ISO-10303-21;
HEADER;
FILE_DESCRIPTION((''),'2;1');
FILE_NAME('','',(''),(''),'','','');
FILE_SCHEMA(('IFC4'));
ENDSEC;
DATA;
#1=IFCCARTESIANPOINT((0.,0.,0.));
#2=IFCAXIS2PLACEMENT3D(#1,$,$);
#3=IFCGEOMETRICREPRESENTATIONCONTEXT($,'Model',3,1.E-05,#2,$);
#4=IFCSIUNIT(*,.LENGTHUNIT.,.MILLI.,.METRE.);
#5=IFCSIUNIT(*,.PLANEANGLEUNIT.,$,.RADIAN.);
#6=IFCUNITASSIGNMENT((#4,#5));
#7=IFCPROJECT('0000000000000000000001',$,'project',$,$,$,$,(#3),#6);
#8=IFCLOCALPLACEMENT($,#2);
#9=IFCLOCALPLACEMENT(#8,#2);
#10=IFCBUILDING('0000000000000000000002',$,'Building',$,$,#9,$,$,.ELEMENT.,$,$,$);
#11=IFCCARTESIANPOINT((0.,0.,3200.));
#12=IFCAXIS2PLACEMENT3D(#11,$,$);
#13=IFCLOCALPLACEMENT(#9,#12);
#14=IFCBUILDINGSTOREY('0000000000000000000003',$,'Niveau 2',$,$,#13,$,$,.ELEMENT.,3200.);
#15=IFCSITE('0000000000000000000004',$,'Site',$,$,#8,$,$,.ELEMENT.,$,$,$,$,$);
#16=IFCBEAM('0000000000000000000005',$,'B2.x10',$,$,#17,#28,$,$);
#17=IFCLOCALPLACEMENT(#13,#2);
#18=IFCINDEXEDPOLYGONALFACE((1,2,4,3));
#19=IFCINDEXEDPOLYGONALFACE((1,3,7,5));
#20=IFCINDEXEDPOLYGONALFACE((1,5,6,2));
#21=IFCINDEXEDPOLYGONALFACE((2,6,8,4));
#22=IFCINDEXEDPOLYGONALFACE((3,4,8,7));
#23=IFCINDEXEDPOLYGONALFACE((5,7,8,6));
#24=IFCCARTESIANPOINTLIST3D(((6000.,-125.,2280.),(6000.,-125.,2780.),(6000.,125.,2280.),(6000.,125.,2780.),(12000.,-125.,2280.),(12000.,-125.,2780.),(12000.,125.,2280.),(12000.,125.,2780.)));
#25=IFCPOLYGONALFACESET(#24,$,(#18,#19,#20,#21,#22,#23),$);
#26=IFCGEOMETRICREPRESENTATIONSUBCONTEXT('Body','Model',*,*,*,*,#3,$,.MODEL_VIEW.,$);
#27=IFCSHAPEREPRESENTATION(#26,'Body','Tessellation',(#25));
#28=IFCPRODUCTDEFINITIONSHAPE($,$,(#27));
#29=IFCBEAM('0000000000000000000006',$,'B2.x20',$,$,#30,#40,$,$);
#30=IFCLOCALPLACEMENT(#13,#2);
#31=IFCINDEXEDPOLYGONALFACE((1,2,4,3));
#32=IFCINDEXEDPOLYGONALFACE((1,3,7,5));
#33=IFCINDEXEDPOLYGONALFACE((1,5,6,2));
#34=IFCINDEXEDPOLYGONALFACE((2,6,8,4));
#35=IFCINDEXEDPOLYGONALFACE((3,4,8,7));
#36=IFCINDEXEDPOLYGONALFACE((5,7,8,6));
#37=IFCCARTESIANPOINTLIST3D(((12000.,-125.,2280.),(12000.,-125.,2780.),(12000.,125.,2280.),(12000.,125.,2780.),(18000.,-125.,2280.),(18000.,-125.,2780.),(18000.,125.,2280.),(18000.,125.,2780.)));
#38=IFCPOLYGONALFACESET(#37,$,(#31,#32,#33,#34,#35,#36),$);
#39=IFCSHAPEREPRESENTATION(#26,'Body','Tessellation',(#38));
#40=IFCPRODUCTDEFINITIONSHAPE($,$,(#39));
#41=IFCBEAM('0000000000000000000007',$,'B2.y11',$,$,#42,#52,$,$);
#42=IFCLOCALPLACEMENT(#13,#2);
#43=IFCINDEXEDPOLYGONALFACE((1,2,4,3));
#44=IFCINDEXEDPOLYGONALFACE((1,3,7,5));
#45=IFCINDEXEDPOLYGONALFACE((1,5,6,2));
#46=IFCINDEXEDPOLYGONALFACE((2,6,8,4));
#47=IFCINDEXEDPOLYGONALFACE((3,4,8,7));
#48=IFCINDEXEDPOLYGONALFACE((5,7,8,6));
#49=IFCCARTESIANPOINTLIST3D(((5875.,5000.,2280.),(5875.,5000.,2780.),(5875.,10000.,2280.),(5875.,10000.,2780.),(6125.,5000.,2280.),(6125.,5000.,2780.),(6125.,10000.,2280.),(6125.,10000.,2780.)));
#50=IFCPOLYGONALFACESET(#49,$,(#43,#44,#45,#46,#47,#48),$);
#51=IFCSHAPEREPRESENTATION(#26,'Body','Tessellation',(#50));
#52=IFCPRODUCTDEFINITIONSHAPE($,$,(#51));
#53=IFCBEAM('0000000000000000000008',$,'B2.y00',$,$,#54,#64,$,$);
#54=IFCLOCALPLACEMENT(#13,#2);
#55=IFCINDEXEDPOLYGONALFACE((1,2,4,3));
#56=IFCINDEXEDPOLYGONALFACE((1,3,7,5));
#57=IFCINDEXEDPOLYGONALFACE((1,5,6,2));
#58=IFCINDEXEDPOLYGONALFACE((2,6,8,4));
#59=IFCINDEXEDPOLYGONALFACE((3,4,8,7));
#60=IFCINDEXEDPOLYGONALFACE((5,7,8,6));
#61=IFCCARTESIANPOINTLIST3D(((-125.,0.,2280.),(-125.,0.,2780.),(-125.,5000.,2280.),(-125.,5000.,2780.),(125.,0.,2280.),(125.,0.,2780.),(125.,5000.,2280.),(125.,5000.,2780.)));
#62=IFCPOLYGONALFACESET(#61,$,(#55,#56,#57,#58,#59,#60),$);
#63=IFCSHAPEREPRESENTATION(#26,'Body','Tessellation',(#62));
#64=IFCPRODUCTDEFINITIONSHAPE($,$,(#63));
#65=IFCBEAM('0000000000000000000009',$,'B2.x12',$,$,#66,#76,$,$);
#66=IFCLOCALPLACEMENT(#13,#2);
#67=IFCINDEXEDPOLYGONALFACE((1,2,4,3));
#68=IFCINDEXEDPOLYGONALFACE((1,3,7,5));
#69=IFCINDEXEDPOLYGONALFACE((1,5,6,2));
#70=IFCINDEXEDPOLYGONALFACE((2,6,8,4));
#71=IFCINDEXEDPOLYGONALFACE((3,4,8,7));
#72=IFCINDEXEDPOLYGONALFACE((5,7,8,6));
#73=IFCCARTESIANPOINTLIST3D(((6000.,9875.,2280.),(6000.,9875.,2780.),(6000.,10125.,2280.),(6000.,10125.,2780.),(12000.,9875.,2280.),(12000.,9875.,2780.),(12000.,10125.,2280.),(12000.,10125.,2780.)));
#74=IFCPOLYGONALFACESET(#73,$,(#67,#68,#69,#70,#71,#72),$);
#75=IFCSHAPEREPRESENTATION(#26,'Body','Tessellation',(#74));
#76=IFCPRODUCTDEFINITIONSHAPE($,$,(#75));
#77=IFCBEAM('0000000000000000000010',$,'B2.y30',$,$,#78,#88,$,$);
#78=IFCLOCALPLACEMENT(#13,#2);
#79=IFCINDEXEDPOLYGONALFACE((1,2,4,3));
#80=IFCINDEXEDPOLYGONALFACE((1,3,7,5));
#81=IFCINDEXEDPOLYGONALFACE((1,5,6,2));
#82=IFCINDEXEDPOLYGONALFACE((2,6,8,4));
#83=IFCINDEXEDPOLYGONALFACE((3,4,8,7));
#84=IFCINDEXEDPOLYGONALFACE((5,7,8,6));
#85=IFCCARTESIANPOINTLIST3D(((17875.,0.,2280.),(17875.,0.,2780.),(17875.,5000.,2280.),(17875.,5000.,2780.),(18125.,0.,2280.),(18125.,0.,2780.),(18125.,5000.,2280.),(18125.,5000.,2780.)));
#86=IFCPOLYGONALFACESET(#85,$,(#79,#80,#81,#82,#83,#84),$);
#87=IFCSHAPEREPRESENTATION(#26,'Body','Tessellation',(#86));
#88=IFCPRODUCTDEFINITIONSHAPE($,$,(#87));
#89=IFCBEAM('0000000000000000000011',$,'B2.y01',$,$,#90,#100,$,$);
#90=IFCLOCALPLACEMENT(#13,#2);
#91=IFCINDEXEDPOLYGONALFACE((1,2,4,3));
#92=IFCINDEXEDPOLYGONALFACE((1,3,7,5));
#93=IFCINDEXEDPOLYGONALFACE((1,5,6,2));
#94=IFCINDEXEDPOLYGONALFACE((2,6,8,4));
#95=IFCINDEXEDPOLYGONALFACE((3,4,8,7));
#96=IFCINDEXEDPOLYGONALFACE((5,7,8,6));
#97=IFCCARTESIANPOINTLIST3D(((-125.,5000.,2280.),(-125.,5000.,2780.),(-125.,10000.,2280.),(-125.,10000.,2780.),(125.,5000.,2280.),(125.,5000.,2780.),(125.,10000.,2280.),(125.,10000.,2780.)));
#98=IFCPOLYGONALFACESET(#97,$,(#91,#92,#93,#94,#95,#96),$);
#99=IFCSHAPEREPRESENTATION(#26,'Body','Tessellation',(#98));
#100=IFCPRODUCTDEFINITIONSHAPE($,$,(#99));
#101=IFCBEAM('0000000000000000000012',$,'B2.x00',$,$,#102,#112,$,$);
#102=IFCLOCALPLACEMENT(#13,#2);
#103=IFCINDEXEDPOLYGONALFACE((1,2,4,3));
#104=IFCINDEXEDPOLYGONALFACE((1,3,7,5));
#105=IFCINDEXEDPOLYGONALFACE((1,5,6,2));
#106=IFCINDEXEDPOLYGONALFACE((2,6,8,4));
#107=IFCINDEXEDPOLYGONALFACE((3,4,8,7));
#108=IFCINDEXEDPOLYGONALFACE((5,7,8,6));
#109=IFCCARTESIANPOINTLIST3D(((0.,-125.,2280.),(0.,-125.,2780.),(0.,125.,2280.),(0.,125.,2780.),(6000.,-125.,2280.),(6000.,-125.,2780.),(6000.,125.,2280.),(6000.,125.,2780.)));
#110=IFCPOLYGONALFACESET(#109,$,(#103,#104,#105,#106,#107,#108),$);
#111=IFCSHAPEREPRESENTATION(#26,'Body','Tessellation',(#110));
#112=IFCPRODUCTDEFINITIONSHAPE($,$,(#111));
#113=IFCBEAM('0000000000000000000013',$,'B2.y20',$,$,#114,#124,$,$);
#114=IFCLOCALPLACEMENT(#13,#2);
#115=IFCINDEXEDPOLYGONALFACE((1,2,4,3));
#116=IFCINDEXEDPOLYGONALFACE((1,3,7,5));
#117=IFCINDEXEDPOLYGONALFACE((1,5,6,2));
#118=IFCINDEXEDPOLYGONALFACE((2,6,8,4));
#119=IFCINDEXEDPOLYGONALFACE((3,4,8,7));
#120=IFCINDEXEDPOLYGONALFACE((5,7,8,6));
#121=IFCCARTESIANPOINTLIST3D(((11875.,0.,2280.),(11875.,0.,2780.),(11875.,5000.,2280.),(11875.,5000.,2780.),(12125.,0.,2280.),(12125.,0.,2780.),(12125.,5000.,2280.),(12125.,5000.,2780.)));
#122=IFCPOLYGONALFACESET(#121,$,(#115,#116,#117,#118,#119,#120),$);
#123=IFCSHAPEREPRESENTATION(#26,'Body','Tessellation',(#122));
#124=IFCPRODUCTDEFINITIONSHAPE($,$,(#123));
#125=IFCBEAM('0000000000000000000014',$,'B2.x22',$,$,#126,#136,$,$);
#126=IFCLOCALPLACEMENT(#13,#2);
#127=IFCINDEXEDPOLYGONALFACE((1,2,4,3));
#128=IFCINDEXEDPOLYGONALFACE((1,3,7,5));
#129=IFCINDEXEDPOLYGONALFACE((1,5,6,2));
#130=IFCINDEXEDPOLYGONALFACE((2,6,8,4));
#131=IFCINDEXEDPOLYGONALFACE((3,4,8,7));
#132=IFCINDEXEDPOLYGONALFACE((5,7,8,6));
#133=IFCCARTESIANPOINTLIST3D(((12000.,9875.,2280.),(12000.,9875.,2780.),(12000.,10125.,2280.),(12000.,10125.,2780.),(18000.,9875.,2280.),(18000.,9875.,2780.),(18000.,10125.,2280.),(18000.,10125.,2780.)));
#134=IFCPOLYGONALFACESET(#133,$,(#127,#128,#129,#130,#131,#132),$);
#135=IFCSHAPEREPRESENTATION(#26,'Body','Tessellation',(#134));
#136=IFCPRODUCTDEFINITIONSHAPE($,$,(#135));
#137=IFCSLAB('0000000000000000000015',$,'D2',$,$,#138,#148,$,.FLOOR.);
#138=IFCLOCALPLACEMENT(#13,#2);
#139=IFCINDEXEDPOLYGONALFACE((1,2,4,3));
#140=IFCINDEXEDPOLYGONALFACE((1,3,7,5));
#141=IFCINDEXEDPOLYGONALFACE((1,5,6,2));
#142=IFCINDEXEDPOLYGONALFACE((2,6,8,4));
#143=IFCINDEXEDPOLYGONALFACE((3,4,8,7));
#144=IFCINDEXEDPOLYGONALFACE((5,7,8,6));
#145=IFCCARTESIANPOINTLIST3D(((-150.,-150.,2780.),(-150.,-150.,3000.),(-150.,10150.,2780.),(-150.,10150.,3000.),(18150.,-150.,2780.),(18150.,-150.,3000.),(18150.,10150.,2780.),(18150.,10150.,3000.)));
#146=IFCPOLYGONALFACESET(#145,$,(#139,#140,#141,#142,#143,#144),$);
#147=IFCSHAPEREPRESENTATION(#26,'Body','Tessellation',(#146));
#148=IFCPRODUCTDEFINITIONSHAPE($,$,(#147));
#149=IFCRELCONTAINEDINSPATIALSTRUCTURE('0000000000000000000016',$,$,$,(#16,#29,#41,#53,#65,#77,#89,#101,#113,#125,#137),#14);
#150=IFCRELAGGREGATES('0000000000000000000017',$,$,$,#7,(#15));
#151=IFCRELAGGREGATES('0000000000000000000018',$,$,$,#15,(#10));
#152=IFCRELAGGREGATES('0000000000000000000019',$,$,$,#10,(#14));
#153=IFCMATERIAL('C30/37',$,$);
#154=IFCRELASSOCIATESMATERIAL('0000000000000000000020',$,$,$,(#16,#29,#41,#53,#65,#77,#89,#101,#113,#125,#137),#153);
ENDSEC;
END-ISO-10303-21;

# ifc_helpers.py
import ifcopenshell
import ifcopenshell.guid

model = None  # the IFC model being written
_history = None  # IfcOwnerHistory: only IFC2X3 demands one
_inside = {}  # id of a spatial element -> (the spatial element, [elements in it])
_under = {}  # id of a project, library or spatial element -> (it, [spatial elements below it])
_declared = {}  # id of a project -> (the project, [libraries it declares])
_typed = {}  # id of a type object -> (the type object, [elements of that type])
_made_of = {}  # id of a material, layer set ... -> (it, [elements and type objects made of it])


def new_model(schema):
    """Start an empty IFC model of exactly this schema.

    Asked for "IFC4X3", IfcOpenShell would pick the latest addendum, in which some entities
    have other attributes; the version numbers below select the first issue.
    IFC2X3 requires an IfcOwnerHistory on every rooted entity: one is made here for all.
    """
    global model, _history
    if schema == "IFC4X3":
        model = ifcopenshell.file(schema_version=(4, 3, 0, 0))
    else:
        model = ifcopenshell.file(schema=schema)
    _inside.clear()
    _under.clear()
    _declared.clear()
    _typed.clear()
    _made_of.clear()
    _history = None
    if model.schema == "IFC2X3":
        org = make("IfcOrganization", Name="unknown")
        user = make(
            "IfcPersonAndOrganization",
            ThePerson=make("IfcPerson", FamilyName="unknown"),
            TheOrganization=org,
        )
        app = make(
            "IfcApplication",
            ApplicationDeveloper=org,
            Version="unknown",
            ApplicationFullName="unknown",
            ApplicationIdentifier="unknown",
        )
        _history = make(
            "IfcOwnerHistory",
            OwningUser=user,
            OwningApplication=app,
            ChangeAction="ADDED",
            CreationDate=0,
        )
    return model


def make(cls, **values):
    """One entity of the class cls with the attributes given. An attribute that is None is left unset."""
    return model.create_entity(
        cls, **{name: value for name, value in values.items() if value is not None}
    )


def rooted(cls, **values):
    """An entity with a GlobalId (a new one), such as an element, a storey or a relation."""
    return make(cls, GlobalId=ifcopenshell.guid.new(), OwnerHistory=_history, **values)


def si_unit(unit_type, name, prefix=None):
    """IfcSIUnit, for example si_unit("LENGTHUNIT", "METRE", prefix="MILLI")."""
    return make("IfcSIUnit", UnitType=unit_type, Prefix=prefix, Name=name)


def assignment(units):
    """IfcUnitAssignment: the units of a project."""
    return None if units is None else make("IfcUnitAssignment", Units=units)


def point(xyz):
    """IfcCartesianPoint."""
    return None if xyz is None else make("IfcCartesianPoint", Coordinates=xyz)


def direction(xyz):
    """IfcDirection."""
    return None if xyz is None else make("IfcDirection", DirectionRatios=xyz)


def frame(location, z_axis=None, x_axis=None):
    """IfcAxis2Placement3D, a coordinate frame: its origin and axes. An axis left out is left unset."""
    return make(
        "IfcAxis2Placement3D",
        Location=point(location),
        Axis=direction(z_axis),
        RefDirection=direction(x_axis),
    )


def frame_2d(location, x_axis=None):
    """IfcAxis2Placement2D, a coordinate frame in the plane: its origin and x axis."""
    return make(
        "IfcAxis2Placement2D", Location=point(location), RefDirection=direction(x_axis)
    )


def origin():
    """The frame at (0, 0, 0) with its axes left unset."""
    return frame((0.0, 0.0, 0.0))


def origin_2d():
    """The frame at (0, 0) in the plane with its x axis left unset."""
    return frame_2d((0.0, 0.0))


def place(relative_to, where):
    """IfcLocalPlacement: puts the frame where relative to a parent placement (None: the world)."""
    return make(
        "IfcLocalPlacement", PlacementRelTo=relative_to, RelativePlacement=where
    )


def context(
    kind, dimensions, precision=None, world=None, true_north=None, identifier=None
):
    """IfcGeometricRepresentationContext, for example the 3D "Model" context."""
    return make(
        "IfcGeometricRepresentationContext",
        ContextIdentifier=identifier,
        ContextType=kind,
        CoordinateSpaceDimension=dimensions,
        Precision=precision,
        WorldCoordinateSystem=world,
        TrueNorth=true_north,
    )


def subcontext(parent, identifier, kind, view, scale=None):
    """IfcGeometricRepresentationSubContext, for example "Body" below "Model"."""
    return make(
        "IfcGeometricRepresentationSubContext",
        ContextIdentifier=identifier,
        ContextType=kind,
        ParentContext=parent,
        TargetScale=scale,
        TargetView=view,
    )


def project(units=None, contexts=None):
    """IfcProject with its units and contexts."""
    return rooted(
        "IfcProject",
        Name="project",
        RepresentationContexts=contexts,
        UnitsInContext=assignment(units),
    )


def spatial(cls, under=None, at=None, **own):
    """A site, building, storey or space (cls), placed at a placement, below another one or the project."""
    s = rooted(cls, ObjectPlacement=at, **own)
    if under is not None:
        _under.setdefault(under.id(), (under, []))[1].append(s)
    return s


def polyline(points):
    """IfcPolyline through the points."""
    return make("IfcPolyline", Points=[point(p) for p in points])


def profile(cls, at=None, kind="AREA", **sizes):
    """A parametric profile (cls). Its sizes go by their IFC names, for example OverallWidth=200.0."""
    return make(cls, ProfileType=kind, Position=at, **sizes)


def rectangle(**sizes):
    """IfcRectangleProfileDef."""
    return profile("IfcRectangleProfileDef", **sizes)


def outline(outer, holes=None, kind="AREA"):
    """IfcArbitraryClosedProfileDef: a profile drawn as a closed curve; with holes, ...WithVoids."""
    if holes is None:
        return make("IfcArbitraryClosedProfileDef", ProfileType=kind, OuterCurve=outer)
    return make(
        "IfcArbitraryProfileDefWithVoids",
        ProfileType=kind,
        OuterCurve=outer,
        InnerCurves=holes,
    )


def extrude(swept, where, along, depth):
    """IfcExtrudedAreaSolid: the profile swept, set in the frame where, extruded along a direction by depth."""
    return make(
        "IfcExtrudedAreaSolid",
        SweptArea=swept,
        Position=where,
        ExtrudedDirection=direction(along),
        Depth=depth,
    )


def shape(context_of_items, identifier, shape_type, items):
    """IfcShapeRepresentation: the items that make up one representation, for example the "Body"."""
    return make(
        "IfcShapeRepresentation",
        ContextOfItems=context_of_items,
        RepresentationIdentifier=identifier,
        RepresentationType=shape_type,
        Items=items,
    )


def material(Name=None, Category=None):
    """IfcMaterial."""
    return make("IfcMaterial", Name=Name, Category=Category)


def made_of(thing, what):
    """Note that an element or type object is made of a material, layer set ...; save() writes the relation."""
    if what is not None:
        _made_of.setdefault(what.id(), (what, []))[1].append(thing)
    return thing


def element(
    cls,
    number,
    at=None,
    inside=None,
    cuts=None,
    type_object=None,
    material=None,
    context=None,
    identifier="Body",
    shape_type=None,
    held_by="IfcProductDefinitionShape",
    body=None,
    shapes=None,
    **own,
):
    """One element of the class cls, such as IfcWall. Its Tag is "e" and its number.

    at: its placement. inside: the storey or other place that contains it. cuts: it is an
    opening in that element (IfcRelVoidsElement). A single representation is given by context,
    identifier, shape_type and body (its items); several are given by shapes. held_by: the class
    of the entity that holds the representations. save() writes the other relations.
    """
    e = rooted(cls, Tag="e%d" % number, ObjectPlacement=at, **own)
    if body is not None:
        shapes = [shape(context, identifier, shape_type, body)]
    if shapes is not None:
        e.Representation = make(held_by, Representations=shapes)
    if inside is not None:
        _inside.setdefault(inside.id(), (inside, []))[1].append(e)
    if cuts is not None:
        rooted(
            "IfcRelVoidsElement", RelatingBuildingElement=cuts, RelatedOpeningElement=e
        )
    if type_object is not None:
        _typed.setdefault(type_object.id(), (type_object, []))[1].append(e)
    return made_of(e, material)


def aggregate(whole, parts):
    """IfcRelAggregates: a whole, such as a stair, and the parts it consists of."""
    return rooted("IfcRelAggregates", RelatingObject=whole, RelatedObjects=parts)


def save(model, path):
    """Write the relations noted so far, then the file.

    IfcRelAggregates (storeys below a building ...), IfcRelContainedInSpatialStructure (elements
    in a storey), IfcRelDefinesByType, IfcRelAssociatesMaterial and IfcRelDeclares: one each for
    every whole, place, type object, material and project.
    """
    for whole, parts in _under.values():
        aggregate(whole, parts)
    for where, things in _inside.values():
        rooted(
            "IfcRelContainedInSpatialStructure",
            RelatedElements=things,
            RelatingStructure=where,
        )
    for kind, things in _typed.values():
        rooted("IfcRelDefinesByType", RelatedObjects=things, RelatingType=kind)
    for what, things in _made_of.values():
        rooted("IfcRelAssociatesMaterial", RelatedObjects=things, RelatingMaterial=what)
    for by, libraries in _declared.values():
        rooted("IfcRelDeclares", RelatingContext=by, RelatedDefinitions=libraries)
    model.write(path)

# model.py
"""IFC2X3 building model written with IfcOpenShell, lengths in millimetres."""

from ifc_helpers import new_model, si_unit, frame, origin, origin_2d, place, context, subcontext, project, spatial, polyline, rectangle, outline, extrude, material, element, save


model = new_model("IFC2X3")

# Units and contexts
model_context = context("Model", 3, precision=1e-05, world=origin())
body_context = subcontext(model_context, "Body", "Model", "MODEL_VIEW")
ifc_project = project(units=[si_unit("LENGTHUNIT", "METRE", prefix="MILLI"), si_unit("PLANEANGLEUNIT", "RADIAN")], contexts=[model_context])

# Site, building, storey
site_placement = place(None, origin())
site = spatial("IfcSite", under=ifc_project, at=site_placement, Name="Site", CompositionType="ELEMENT")
building_placement = place(site_placement, origin())
building = spatial("IfcBuilding", under=site, at=building_placement, Name="Building", CompositionType="ELEMENT")
storey_placement = place(building_placement, frame((0.0, 0.0, 3200.0)))
storey = spatial("IfcBuildingStorey", under=building, at=storey_placement, Name="Niveau 2", CompositionType="ELEMENT", Elevation=3200.0)

# Shared definitions
ifc_material = material(Name="C30/37")

# Beams
for number, where, z_axis, x_axis, name in (
    (1, (6000.0, 0.0, 2530.0), (1.0, 0.0, 0.0), (0.0, 1.0, 0.0), "B2.x10"),
    (2, (12000.0, 0.0, 2530.0), (1.0, 0.0, 0.0), (0.0, 1.0, 0.0), "B2.x20"),
):
    element("IfcBeam", number, at=place(storey_placement, frame(where, z_axis=z_axis, x_axis=x_axis)), inside=storey, material=ifc_material, Name=name, context=body_context, shape_type="SweptSolid", body=[
        extrude(rectangle(XDim=250.0, YDim=500.0, at=origin_2d()), origin(), (0.0, 0.0, 1.0), 6000.0),
    ])
for number, where, z_axis, x_axis, name in (
    (3, (6000.0, 5000.0, 2530.0), (0.0, 1.0, 0.0), (-1.0, 0.0, 0.0), "B2.y11"),
    (4, (0.0, 0.0, 2530.0), (0.0, 1.0, 0.0), (-1.0, 0.0, 0.0), "B2.y00"),
):
    element("IfcBeam", number, at=place(storey_placement, frame(where, z_axis=z_axis, x_axis=x_axis)), inside=storey, material=ifc_material, Name=name, context=body_context, shape_type="SweptSolid", body=[
        extrude(rectangle(XDim=250.0, YDim=500.0, at=origin_2d()), origin(), (0.0, 0.0, 1.0), 5000.0),
    ])
beam_1_placement = place(storey_placement, frame((6000.0, 10000.0, 2530.0), z_axis=(1.0, 0.0, 0.0), x_axis=(0.0, 1.0, 0.0)))
element("IfcBeam", 5, at=beam_1_placement, inside=storey, material=ifc_material, Name="B2.x12", context=body_context, shape_type="SweptSolid", body=[
    extrude(rectangle(XDim=250.0, YDim=500.0, at=origin_2d()), origin(), (0.0, 0.0, 1.0), 6000.0),
])
for number, where, z_axis, x_axis, name in (
    (6, (18000.0, 0.0, 2530.0), (0.0, 1.0, 0.0), (-1.0, 0.0, 0.0), "B2.y30"),
    (7, (0.0, 5000.0, 2530.0), (0.0, 1.0, 0.0), (-1.0, 0.0, 0.0), "B2.y01"),
):
    element("IfcBeam", number, at=place(storey_placement, frame(where, z_axis=z_axis, x_axis=x_axis)), inside=storey, material=ifc_material, Name=name, context=body_context, shape_type="SweptSolid", body=[
        extrude(rectangle(XDim=250.0, YDim=500.0, at=origin_2d()), origin(), (0.0, 0.0, 1.0), 5000.0),
    ])
beam_2_placement = place(storey_placement, frame((0.0, 0.0, 2530.0), z_axis=(1.0, 0.0, 0.0), x_axis=(0.0, 1.0, 0.0)))
element("IfcBeam", 8, at=beam_2_placement, inside=storey, material=ifc_material, Name="B2.x00", context=body_context, shape_type="SweptSolid", body=[
    extrude(rectangle(XDim=250.0, YDim=500.0, at=origin_2d()), origin(), (0.0, 0.0, 1.0), 6000.0),
])
beam_3_placement = place(storey_placement, frame((12000.0, 0.0, 2530.0), z_axis=(0.0, 1.0, 0.0), x_axis=(-1.0, 0.0, 0.0)))
element("IfcBeam", 9, at=beam_3_placement, inside=storey, material=ifc_material, Name="B2.y20", context=body_context, shape_type="SweptSolid", body=[
    extrude(rectangle(XDim=250.0, YDim=500.0, at=origin_2d()), origin(), (0.0, 0.0, 1.0), 5000.0),
])
beam_4_placement = place(storey_placement, frame((12000.0, 10000.0, 2530.0), z_axis=(1.0, 0.0, 0.0), x_axis=(0.0, 1.0, 0.0)))
element("IfcBeam", 10, at=beam_4_placement, inside=storey, material=ifc_material, Name="B2.x22", context=body_context, shape_type="SweptSolid", body=[
    extrude(rectangle(XDim=250.0, YDim=500.0, at=origin_2d()), origin(), (0.0, 0.0, 1.0), 6000.0),
])

# Slab
slab_placement = place(storey_placement, frame((0.0, 0.0, 2780.0), z_axis=(0.0, 0.0, 1.0), x_axis=(1.0, 0.0, 0.0)))
element("IfcSlab", 11, at=slab_placement, inside=storey, material=ifc_material, Name="D2", PredefinedType="FLOOR", context=body_context, shape_type="SweptSolid", body=[
    extrude(outline(polyline([(-150.0, -150.0), (18150.0, -150.0), (18150.0, 10150.0), (-150.0, 10150.0), (-150.0, -150.0)])), origin(), (0.0, 0.0, 1.0), 220.0),
])

save(model, "model.ifc")
